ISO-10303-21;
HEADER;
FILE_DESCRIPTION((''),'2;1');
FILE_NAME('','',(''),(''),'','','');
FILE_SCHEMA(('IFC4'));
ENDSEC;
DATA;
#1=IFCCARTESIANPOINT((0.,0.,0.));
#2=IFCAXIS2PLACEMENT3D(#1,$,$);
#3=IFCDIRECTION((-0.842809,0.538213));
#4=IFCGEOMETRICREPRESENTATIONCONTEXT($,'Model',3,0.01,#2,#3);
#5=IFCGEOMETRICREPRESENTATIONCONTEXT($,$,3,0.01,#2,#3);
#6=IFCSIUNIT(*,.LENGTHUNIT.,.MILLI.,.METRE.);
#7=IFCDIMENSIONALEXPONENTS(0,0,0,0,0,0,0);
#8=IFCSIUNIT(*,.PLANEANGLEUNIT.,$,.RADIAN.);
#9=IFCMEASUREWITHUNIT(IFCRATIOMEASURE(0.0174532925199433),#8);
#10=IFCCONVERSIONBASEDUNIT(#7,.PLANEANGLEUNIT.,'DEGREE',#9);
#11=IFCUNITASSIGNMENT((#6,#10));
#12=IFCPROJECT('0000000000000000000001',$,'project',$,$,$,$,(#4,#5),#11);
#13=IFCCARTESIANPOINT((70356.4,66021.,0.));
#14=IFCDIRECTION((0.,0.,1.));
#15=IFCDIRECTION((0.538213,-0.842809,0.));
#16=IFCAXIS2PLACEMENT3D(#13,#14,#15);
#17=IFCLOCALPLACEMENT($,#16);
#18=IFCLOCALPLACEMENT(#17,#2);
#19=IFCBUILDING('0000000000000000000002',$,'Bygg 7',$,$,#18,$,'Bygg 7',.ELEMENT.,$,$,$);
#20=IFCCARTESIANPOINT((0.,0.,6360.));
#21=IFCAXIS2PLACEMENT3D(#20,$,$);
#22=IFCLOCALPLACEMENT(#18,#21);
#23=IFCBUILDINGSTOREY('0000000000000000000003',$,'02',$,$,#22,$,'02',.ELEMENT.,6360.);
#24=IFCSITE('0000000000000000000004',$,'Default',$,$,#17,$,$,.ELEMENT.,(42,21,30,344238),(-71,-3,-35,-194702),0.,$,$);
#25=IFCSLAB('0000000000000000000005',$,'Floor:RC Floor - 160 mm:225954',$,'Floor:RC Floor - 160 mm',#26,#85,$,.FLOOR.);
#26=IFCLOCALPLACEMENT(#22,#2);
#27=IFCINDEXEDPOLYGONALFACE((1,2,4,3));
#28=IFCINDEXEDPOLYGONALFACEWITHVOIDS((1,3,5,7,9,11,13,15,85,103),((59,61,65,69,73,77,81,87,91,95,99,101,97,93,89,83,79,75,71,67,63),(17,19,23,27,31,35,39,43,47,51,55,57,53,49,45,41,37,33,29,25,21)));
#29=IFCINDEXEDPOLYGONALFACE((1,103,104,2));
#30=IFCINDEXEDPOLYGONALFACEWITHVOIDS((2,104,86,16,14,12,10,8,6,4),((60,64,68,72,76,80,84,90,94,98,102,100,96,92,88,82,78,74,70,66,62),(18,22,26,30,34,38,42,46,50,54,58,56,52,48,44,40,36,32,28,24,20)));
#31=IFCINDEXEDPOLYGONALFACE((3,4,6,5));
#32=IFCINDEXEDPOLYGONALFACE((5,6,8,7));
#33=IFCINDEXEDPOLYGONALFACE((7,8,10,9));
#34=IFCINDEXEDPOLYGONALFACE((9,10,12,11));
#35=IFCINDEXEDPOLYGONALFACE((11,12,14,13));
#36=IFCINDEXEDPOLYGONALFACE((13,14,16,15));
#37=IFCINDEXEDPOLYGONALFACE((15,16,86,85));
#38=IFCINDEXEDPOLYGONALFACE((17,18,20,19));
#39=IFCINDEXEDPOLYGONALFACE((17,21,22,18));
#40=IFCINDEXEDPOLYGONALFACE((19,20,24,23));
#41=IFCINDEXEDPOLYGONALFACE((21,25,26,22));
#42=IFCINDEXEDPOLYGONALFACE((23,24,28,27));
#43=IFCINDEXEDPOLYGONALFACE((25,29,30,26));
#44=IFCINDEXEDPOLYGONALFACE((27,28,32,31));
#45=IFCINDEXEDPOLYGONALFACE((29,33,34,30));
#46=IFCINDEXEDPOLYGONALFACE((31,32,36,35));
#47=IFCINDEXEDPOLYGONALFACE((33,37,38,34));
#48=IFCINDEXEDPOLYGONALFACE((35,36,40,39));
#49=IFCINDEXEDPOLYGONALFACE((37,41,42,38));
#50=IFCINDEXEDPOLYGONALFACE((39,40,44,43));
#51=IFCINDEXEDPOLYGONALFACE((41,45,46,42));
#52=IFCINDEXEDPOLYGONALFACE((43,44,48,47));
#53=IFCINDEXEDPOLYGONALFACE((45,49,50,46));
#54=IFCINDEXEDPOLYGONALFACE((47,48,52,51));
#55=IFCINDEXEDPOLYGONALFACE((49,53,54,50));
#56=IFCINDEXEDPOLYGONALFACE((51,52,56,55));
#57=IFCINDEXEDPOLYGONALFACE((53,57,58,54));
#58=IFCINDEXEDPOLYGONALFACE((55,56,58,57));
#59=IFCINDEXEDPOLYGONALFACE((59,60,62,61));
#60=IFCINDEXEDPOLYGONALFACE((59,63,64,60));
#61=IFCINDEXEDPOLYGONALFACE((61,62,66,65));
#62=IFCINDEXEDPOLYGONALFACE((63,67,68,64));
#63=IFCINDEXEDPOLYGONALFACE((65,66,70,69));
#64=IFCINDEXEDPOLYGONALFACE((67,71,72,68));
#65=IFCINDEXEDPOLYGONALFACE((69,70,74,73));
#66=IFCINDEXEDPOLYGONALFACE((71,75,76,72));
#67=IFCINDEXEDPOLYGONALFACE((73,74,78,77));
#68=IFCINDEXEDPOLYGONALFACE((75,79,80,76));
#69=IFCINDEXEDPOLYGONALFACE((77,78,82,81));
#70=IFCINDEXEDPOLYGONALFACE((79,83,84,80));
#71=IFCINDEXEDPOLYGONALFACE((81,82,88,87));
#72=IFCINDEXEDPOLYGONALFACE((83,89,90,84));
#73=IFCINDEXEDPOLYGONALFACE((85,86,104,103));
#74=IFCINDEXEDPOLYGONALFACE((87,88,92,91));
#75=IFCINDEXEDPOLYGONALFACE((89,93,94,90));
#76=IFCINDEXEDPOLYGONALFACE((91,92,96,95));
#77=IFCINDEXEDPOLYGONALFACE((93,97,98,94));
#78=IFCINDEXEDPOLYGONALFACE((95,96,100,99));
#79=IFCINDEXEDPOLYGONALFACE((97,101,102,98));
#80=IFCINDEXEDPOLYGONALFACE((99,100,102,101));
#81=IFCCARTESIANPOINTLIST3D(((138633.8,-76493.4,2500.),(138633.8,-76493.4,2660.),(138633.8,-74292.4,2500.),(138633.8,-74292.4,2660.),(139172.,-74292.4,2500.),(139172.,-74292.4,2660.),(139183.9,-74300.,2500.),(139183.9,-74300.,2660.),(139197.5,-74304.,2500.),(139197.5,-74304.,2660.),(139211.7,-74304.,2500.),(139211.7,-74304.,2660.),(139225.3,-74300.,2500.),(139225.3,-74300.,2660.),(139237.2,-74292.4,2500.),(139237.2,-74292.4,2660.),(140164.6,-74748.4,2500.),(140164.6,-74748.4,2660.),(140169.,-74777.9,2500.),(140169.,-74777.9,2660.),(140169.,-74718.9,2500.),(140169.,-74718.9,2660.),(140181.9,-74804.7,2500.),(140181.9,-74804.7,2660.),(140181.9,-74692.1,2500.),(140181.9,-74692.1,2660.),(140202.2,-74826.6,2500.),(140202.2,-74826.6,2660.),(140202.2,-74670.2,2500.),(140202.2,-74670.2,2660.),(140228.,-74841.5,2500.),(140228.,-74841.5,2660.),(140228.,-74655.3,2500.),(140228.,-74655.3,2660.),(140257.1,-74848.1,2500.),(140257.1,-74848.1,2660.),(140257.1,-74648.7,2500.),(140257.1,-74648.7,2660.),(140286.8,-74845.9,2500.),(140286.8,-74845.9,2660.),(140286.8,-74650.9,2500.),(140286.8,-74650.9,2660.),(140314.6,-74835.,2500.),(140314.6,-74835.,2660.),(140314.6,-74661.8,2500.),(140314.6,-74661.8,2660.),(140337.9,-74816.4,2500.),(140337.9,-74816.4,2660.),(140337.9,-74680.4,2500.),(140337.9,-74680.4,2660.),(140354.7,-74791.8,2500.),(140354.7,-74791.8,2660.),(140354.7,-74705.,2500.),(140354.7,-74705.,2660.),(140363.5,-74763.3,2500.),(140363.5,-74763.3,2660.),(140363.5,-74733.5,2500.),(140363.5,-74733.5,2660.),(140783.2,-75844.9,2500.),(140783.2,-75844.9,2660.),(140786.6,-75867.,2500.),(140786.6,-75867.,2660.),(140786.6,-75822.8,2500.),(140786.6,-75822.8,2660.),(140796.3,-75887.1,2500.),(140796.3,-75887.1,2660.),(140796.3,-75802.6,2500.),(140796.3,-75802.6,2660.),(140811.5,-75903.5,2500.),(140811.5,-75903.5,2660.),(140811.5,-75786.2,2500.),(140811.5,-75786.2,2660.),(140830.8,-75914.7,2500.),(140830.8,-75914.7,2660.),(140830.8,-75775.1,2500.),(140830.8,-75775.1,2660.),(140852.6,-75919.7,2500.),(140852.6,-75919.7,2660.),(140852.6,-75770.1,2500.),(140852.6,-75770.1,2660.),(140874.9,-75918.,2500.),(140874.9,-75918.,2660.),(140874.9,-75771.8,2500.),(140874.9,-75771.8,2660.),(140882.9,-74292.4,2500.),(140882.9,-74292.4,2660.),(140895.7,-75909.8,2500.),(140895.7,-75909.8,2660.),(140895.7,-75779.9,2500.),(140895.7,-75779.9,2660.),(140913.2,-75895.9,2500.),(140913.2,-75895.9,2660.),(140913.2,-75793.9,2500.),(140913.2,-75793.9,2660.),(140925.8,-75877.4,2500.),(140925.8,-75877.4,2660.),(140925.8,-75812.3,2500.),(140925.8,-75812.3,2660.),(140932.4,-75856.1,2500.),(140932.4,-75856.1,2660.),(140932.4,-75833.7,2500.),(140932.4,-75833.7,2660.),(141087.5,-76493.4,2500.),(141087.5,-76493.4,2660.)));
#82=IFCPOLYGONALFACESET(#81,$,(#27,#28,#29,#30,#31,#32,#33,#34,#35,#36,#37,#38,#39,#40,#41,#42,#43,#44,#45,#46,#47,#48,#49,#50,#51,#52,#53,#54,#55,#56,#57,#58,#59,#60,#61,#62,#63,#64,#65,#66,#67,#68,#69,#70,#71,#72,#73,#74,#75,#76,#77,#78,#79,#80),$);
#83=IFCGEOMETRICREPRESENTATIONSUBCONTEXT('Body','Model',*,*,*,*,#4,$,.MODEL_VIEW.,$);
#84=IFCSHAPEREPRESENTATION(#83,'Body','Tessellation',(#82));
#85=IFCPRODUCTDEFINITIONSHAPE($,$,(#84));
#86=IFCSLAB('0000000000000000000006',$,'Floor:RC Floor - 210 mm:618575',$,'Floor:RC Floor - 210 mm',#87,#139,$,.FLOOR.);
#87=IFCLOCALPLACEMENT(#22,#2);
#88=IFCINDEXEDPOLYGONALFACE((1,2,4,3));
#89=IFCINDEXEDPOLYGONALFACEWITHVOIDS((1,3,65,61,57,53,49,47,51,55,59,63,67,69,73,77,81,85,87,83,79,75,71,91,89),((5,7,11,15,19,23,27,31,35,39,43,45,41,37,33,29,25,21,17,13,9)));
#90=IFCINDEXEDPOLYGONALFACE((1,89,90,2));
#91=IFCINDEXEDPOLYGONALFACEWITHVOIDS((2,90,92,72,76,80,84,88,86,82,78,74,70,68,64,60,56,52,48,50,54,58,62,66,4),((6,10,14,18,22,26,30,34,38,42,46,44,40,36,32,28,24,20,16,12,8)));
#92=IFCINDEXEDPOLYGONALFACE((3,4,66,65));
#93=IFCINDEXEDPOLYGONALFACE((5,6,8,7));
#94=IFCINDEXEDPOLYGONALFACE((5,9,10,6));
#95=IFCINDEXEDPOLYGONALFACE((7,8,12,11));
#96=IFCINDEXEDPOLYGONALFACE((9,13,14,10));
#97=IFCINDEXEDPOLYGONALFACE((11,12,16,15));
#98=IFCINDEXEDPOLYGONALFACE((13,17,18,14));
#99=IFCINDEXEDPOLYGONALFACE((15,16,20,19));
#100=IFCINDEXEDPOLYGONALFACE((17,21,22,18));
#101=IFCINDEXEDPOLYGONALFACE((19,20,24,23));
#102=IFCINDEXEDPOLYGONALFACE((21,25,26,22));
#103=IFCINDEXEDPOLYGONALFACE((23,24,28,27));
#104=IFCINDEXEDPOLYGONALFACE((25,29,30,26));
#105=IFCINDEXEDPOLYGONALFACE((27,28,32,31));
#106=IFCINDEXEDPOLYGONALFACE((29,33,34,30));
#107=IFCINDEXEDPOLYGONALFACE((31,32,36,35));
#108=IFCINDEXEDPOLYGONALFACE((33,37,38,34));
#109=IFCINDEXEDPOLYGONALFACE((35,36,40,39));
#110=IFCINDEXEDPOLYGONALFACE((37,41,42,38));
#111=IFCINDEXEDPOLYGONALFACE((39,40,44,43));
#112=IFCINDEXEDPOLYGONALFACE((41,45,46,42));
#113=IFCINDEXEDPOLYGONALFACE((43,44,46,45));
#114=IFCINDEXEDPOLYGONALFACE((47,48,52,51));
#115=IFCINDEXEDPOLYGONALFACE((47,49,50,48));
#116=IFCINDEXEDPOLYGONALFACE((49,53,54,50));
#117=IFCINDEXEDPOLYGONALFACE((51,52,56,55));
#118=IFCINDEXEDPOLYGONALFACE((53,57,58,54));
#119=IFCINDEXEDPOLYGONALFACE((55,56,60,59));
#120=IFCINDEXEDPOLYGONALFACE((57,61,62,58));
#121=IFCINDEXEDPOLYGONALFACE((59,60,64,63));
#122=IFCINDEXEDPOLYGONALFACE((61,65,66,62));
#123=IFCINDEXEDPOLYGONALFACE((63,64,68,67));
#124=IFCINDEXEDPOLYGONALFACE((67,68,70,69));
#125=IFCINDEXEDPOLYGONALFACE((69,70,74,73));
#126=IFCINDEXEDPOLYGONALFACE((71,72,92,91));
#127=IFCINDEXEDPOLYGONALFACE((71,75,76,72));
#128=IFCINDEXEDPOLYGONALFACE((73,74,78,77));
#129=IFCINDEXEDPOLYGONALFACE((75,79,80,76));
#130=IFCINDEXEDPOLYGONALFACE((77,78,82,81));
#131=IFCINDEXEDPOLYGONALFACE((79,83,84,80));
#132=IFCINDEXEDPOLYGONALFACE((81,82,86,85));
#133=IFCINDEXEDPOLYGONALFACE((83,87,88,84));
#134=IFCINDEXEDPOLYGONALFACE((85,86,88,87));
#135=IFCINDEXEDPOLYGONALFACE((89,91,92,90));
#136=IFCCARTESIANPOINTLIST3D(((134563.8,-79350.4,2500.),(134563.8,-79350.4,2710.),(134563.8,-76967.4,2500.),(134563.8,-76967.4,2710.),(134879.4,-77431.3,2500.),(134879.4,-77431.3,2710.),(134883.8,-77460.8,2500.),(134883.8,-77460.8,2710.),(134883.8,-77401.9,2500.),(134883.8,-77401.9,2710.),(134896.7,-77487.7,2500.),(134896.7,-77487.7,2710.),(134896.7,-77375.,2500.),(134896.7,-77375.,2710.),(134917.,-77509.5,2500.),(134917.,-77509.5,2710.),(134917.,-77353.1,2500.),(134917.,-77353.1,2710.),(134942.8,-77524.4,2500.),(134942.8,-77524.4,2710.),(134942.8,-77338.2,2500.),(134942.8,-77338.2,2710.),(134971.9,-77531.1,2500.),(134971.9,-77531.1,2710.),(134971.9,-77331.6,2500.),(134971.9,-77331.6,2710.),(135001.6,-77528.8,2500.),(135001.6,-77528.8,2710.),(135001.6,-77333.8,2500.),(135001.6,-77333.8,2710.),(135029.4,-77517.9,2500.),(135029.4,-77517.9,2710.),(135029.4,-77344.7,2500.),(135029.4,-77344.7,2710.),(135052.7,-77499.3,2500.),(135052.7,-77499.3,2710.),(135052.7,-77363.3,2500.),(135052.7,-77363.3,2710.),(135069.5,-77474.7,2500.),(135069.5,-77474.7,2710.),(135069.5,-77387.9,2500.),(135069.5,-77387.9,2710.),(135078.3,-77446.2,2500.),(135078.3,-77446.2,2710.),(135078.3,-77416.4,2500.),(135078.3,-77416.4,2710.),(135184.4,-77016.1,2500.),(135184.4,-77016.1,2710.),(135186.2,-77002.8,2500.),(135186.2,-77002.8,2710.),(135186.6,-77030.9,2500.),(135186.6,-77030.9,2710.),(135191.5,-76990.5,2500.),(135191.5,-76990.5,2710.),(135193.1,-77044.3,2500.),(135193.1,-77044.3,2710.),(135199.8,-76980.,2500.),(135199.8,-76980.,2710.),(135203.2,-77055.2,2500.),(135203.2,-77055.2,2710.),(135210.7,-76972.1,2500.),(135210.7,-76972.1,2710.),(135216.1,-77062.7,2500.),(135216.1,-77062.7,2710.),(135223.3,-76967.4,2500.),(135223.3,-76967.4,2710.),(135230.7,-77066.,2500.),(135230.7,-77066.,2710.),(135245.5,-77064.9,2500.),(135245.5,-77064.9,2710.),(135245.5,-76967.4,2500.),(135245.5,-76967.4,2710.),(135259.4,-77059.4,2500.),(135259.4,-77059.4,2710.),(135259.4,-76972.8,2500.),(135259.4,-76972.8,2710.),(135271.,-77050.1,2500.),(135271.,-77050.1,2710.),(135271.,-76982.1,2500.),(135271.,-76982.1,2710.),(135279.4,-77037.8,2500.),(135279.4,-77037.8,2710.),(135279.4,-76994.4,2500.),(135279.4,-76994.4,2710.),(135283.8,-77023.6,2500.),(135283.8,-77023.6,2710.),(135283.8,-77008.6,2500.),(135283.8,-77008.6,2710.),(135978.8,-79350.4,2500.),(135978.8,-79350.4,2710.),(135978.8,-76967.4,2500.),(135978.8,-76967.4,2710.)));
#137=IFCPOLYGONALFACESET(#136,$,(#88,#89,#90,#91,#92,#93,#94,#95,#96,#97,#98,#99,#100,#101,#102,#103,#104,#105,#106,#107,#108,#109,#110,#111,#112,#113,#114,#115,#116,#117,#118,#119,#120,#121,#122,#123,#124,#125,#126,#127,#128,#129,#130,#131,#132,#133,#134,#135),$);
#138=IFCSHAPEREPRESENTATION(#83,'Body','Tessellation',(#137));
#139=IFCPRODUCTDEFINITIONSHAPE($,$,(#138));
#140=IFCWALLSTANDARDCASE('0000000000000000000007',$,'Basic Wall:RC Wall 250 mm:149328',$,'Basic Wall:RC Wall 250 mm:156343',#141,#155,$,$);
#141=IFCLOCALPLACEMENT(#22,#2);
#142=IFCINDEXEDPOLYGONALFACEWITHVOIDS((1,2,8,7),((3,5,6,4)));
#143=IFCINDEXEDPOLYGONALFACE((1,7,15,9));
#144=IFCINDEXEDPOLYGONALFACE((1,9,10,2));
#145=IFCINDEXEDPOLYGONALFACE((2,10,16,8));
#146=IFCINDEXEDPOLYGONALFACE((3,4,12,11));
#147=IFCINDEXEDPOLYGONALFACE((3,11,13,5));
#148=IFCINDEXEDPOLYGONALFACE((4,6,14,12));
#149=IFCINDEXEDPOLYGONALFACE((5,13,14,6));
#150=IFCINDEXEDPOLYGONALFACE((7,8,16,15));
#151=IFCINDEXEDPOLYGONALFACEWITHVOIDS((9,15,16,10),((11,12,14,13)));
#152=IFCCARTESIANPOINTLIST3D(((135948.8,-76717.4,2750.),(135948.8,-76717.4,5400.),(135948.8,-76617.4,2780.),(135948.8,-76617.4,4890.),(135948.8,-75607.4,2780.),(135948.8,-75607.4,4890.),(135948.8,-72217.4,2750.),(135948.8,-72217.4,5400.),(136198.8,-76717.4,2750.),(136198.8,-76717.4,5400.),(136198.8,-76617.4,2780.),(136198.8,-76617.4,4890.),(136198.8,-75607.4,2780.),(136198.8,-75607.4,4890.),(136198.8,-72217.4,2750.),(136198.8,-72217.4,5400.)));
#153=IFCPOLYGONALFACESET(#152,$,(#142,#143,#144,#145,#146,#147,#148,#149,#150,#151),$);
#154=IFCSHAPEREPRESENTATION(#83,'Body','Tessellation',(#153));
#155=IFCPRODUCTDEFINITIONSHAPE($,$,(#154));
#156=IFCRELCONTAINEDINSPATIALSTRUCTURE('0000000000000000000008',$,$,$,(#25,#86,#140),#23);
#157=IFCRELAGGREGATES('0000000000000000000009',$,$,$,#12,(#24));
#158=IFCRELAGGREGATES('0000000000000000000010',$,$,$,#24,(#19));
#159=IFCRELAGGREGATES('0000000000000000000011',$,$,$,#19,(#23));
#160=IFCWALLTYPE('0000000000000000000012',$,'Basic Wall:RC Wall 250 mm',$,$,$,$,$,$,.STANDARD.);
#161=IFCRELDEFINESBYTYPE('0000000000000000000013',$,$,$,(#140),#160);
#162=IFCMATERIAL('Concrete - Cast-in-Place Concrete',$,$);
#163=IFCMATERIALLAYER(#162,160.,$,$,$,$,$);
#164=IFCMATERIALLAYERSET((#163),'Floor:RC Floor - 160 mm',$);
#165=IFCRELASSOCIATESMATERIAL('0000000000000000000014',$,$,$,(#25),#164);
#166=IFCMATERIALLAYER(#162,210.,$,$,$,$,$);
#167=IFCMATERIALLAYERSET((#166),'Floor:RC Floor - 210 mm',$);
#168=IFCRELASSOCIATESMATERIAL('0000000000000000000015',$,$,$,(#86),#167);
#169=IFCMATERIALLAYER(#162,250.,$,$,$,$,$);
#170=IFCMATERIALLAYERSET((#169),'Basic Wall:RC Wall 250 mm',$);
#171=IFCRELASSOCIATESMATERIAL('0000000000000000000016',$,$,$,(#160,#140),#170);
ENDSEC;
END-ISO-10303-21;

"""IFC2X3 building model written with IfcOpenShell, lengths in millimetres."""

from ifc_helpers import new_model, entity, si_unit, converted_unit, direction, frame, frame_2d, origin, origin_2d_with_axis, place, context, subcontext, project, spatial, polyline, rectangle, circle, outline, extrude, clip, bounded_halfspace, material, layer, layer_set, layer_usage, type_object, element, save


model = new_model("IFC2X3")

# Units and contexts
model_context = context("Model", 3, precision=0.01, world=origin(), true_north=direction((-0.842809, 0.538213)))
context_of_model = context(None, 3, precision=0.01, world=origin(), true_north=direction((-0.842809, 0.538213)))
body_context = subcontext(model_context, "Body", "Model", "MODEL_VIEW")
ifc_project = project(units=[si_unit("LENGTHUNIT", "METRE", prefix="MILLI"), converted_unit("PLANEANGLEUNIT", "DEGREE", entity("IfcRatioMeasure", 0.0174532925199433), si_unit("PLANEANGLEUNIT", "RADIAN"), dimensions=[0, 0, 0, 0, 0, 0, 0])], contexts=[model_context, context_of_model])

# Site, building, storey
site_placement = place(None, frame((70356.4, 66021.0, 0.0), z_axis=(0.0, 0.0, 1.0), x_axis=(0.538213, -0.842809, 0.0)))
site = spatial("IfcSite", under=ifc_project, at=site_placement, Name="Default", CompositionType="ELEMENT", RefLatitude=(42, 21, 30, 344238), RefLongitude=(-71, -3, -35, -194702), RefElevation=0.0)
building_placement = place(site_placement, origin())
building = spatial("IfcBuilding", under=site, at=building_placement, Name="Bygg 7", LongName="Bygg 7", CompositionType="ELEMENT")
storey_placement = place(building_placement, frame((0.0, 0.0, 6360.0)))
storey = spatial("IfcBuildingStorey", under=building, at=storey_placement, Name="02", LongName="02", CompositionType="ELEMENT", Elevation=6360.0)

# Slabs, openings
ifc_material_1 = material(Name="Concrete - Cast-in-Place Concrete")
ifc_layer_1 = layer(ifc_material_1, 160.0)
ifc_layer_set_1 = layer_set([ifc_layer_1], Name="Floor:RC Floor - 160 mm")
ifc_layer_usage_1 = layer_usage(ifc_layer_set_1, "AXIS3", "POSITIVE", 0.0)
slab_1_placement = place(storey_placement, frame((138633.8, -76493.4, 2500.0)))
slab_1 = element("IfcSlab", 1, at=slab_1_placement, inside=storey, material=ifc_layer_usage_1, Name="Floor:RC Floor - 160 mm:225954", ObjectType="Floor:RC Floor - 160 mm", PredefinedType="FLOOR", context=body_context, shape_type="SweptSolid", body=[
    extrude(outline(polyline([(1226.8, 1100.5), (-1022.3, 1100.5), (-1226.8, -1100.5), (1226.8, -1100.5), (1226.8, -383.5), (1226.8, 1100.5)])), frame((1226.8, 1100.5, 160.0), z_axis=(0.0, 0.0, -1.0), x_axis=(-1.0, 0.0, 0.0)), (0.0, 0.0, 1.0), 160.0),
])
opening_1_placement = place(storey_placement, frame((138633.8, -76493.4, 2500.0)))
element("IfcOpeningElement", 2, at=opening_1_placement, cuts=slab_1, ObjectType="Opening", context=body_context, shape_type="SweptSolid", body=[
    extrude(circle(Radius=100.0, at=frame_2d((-403.9, 644.5), x_axis=(1.0, 0.0))), frame((1226.8, 1100.5, 160.0), z_axis=(0.0, 0.0, -1.0), x_axis=(-1.0, 0.0, 0.0)), (0.0, 0.0, 1.0), 160.0),
])
opening_2_placement = place(storey_placement, frame((138633.8, -76493.4, 2500.0)))
element("IfcOpeningElement", 3, at=opening_2_placement, cuts=slab_1, ObjectType="Opening", context=body_context, shape_type="SweptSolid", body=[
    extrude(circle(Radius=75.0, at=frame_2d((-997.6, -452.0), x_axis=(1.0, 0.0))), frame((1226.8, 1100.5, 160.0), z_axis=(0.0, 0.0, -1.0), x_axis=(-1.0, 0.0, 0.0)), (0.0, 0.0, 1.0), 160.0),
])
opening_3_placement = place(storey_placement, frame((138633.8, -76493.4, 2500.0)))
element("IfcOpeningElement", 4, at=opening_3_placement, cuts=slab_1, ObjectType="Opening", context=body_context, shape_type="SweptSolid", body=[
    extrude(circle(Radius=50.0, at=frame_2d((656.1, 1138.4), x_axis=(1.0, 0.0))), frame((1226.8, 1100.5, 160.0), z_axis=(0.0, 0.0, -1.0), x_axis=(-1.0, 0.0, 0.0)), (0.0, 0.0, 1.0), 160.0),
])
ifc_layer_2 = layer(ifc_material_1, 210.0)
ifc_layer_set_2 = layer_set([ifc_layer_2], Name="Floor:RC Floor - 210 mm")
ifc_layer_usage_2 = layer_usage(ifc_layer_set_2, "AXIS3", "POSITIVE", 0.0)
slab_2_placement = place(storey_placement, frame((134563.8, -79350.4, 2500.0)))
slab_2 = element("IfcSlab", 5, at=slab_2_placement, inside=storey, material=ifc_layer_usage_2, Name="Floor:RC Floor - 210 mm:618575", ObjectType="Floor:RC Floor - 210 mm", PredefinedType="FLOOR", context=body_context, shape_type="SweptSolid", body=[
    extrude(rectangle(XDim=2383.0, YDim=1415.0, at=frame_2d((0.0, 0.0), x_axis=(0.0, -1.0))), frame((707.5, 1191.5, 210.0), z_axis=(0.0, 0.0, -1.0), x_axis=(-1.0, 0.0, 0.0)), (0.0, 0.0, 1.0), 210.0),
])
opening_4_placement = place(storey_placement, frame((134563.8, -79350.4, 2500.0)))
element("IfcOpeningElement", 6, at=opening_4_placement, cuts=slab_2, ObjectType="Opening", context=body_context, shape_type="SweptSolid", body=[
    extrude(circle(Radius=100.0, at=frame_2d((292.0, 727.5), x_axis=(1.0, 0.0))), frame((707.5, 1191.5, 210.0), z_axis=(0.0, 0.0, -1.0), x_axis=(-1.0, 0.0, 0.0)), (0.0, 0.0, 1.0), 210.0),
])
opening_5_placement = place(storey_placement, frame((134563.8, -79350.4, 2500.0)))
element("IfcOpeningElement", 7, at=opening_5_placement, cuts=slab_2, ObjectType="Opening", context=body_context, shape_type="SweptSolid", body=[
    extrude(circle(Radius=50.0, at=frame_2d((37.0, 1142.8), x_axis=(1.0, 0.0))), frame((707.5, 1191.5, 210.0), z_axis=(0.0, 0.0, -1.0), x_axis=(-1.0, 0.0, 0.0)), (0.0, 0.0, 1.0), 210.0),
])

# Wall, opening
ifc_layer_3 = layer(ifc_material_1, 250.0)
ifc_layer_set_3 = layer_set([ifc_layer_3], Name="Basic Wall:RC Wall 250 mm")
ifc_layer_usage_3 = layer_usage(ifc_layer_set_3, "AXIS2", "NEGATIVE", 125.0)
wall_type_1 = type_object("IfcWallType", Name="Basic Wall:RC Wall 250 mm", PredefinedType="STANDARD", material=ifc_layer_set_3)
wall_1_placement = place(storey_placement, frame((136073.8, -76717.4, 2750.0), z_axis=(0.0, 0.0, 1.0), x_axis=(0.0, 1.0, 0.0)))
wall_1 = element("IfcWallStandardCase", 8, at=wall_1_placement, inside=storey, type_object=wall_type_1, material=ifc_layer_usage_3, Name="Basic Wall:RC Wall 250 mm:149328", ObjectType="Basic Wall:RC Wall 250 mm:156343", context=body_context, shape_type="Clipping", body=[
    clip(clip(extrude(rectangle(XDim=4500.0, YDim=250.0, at=frame_2d((2250.0, 0.0), x_axis=(-1.0, 0.0))), origin(), (0.0, 0.0, 1.0), 2650.0), bounded_halfspace(frame((0.0, -125.0, 2650.0), z_axis=(0.0, 0.0, -1.0), x_axis=(-0.99571, -0.092529, 0.0)), True, frame((0.0, -125.0, 2650.0)), polyline([(0.0, 0.0), (4500.0, 0.0), (4500.0, 250.0), (4250.0, 250.0), (0.0, 250.0), (0.0, 0.0)]))), bounded_halfspace(frame((4500.0, -125.0, 0.0), z_axis=(0.0, 0.0, 1.0), x_axis=(0.0, 1.0, 0.0)), True, frame((4500.0, -125.0, 0.0)), polyline([(0.0, 0.0), (0.0, 111.0), (0.0, 250.0), (-4500.0, 250.0), (-4500.0, 0.0), (0.0, 0.0)]))),
])
opening_6_placement = place(wall_1_placement, origin())
element("IfcOpeningElement", 9, at=opening_6_placement, cuts=wall_1, ObjectType="Opening", context=body_context, shape_type="SweptSolid", body=[
    extrude(rectangle(XDim=2110.0, YDim=1010.0, at=origin_2d_with_axis()), frame((605.0, -125.0, 1085.0), z_axis=(0.0, 1.0, 0.0), x_axis=(0.0, 0.0, -1.0)), (0.0, 0.0, 1.0), 250.0),
])

save(model, "model.ifc")
